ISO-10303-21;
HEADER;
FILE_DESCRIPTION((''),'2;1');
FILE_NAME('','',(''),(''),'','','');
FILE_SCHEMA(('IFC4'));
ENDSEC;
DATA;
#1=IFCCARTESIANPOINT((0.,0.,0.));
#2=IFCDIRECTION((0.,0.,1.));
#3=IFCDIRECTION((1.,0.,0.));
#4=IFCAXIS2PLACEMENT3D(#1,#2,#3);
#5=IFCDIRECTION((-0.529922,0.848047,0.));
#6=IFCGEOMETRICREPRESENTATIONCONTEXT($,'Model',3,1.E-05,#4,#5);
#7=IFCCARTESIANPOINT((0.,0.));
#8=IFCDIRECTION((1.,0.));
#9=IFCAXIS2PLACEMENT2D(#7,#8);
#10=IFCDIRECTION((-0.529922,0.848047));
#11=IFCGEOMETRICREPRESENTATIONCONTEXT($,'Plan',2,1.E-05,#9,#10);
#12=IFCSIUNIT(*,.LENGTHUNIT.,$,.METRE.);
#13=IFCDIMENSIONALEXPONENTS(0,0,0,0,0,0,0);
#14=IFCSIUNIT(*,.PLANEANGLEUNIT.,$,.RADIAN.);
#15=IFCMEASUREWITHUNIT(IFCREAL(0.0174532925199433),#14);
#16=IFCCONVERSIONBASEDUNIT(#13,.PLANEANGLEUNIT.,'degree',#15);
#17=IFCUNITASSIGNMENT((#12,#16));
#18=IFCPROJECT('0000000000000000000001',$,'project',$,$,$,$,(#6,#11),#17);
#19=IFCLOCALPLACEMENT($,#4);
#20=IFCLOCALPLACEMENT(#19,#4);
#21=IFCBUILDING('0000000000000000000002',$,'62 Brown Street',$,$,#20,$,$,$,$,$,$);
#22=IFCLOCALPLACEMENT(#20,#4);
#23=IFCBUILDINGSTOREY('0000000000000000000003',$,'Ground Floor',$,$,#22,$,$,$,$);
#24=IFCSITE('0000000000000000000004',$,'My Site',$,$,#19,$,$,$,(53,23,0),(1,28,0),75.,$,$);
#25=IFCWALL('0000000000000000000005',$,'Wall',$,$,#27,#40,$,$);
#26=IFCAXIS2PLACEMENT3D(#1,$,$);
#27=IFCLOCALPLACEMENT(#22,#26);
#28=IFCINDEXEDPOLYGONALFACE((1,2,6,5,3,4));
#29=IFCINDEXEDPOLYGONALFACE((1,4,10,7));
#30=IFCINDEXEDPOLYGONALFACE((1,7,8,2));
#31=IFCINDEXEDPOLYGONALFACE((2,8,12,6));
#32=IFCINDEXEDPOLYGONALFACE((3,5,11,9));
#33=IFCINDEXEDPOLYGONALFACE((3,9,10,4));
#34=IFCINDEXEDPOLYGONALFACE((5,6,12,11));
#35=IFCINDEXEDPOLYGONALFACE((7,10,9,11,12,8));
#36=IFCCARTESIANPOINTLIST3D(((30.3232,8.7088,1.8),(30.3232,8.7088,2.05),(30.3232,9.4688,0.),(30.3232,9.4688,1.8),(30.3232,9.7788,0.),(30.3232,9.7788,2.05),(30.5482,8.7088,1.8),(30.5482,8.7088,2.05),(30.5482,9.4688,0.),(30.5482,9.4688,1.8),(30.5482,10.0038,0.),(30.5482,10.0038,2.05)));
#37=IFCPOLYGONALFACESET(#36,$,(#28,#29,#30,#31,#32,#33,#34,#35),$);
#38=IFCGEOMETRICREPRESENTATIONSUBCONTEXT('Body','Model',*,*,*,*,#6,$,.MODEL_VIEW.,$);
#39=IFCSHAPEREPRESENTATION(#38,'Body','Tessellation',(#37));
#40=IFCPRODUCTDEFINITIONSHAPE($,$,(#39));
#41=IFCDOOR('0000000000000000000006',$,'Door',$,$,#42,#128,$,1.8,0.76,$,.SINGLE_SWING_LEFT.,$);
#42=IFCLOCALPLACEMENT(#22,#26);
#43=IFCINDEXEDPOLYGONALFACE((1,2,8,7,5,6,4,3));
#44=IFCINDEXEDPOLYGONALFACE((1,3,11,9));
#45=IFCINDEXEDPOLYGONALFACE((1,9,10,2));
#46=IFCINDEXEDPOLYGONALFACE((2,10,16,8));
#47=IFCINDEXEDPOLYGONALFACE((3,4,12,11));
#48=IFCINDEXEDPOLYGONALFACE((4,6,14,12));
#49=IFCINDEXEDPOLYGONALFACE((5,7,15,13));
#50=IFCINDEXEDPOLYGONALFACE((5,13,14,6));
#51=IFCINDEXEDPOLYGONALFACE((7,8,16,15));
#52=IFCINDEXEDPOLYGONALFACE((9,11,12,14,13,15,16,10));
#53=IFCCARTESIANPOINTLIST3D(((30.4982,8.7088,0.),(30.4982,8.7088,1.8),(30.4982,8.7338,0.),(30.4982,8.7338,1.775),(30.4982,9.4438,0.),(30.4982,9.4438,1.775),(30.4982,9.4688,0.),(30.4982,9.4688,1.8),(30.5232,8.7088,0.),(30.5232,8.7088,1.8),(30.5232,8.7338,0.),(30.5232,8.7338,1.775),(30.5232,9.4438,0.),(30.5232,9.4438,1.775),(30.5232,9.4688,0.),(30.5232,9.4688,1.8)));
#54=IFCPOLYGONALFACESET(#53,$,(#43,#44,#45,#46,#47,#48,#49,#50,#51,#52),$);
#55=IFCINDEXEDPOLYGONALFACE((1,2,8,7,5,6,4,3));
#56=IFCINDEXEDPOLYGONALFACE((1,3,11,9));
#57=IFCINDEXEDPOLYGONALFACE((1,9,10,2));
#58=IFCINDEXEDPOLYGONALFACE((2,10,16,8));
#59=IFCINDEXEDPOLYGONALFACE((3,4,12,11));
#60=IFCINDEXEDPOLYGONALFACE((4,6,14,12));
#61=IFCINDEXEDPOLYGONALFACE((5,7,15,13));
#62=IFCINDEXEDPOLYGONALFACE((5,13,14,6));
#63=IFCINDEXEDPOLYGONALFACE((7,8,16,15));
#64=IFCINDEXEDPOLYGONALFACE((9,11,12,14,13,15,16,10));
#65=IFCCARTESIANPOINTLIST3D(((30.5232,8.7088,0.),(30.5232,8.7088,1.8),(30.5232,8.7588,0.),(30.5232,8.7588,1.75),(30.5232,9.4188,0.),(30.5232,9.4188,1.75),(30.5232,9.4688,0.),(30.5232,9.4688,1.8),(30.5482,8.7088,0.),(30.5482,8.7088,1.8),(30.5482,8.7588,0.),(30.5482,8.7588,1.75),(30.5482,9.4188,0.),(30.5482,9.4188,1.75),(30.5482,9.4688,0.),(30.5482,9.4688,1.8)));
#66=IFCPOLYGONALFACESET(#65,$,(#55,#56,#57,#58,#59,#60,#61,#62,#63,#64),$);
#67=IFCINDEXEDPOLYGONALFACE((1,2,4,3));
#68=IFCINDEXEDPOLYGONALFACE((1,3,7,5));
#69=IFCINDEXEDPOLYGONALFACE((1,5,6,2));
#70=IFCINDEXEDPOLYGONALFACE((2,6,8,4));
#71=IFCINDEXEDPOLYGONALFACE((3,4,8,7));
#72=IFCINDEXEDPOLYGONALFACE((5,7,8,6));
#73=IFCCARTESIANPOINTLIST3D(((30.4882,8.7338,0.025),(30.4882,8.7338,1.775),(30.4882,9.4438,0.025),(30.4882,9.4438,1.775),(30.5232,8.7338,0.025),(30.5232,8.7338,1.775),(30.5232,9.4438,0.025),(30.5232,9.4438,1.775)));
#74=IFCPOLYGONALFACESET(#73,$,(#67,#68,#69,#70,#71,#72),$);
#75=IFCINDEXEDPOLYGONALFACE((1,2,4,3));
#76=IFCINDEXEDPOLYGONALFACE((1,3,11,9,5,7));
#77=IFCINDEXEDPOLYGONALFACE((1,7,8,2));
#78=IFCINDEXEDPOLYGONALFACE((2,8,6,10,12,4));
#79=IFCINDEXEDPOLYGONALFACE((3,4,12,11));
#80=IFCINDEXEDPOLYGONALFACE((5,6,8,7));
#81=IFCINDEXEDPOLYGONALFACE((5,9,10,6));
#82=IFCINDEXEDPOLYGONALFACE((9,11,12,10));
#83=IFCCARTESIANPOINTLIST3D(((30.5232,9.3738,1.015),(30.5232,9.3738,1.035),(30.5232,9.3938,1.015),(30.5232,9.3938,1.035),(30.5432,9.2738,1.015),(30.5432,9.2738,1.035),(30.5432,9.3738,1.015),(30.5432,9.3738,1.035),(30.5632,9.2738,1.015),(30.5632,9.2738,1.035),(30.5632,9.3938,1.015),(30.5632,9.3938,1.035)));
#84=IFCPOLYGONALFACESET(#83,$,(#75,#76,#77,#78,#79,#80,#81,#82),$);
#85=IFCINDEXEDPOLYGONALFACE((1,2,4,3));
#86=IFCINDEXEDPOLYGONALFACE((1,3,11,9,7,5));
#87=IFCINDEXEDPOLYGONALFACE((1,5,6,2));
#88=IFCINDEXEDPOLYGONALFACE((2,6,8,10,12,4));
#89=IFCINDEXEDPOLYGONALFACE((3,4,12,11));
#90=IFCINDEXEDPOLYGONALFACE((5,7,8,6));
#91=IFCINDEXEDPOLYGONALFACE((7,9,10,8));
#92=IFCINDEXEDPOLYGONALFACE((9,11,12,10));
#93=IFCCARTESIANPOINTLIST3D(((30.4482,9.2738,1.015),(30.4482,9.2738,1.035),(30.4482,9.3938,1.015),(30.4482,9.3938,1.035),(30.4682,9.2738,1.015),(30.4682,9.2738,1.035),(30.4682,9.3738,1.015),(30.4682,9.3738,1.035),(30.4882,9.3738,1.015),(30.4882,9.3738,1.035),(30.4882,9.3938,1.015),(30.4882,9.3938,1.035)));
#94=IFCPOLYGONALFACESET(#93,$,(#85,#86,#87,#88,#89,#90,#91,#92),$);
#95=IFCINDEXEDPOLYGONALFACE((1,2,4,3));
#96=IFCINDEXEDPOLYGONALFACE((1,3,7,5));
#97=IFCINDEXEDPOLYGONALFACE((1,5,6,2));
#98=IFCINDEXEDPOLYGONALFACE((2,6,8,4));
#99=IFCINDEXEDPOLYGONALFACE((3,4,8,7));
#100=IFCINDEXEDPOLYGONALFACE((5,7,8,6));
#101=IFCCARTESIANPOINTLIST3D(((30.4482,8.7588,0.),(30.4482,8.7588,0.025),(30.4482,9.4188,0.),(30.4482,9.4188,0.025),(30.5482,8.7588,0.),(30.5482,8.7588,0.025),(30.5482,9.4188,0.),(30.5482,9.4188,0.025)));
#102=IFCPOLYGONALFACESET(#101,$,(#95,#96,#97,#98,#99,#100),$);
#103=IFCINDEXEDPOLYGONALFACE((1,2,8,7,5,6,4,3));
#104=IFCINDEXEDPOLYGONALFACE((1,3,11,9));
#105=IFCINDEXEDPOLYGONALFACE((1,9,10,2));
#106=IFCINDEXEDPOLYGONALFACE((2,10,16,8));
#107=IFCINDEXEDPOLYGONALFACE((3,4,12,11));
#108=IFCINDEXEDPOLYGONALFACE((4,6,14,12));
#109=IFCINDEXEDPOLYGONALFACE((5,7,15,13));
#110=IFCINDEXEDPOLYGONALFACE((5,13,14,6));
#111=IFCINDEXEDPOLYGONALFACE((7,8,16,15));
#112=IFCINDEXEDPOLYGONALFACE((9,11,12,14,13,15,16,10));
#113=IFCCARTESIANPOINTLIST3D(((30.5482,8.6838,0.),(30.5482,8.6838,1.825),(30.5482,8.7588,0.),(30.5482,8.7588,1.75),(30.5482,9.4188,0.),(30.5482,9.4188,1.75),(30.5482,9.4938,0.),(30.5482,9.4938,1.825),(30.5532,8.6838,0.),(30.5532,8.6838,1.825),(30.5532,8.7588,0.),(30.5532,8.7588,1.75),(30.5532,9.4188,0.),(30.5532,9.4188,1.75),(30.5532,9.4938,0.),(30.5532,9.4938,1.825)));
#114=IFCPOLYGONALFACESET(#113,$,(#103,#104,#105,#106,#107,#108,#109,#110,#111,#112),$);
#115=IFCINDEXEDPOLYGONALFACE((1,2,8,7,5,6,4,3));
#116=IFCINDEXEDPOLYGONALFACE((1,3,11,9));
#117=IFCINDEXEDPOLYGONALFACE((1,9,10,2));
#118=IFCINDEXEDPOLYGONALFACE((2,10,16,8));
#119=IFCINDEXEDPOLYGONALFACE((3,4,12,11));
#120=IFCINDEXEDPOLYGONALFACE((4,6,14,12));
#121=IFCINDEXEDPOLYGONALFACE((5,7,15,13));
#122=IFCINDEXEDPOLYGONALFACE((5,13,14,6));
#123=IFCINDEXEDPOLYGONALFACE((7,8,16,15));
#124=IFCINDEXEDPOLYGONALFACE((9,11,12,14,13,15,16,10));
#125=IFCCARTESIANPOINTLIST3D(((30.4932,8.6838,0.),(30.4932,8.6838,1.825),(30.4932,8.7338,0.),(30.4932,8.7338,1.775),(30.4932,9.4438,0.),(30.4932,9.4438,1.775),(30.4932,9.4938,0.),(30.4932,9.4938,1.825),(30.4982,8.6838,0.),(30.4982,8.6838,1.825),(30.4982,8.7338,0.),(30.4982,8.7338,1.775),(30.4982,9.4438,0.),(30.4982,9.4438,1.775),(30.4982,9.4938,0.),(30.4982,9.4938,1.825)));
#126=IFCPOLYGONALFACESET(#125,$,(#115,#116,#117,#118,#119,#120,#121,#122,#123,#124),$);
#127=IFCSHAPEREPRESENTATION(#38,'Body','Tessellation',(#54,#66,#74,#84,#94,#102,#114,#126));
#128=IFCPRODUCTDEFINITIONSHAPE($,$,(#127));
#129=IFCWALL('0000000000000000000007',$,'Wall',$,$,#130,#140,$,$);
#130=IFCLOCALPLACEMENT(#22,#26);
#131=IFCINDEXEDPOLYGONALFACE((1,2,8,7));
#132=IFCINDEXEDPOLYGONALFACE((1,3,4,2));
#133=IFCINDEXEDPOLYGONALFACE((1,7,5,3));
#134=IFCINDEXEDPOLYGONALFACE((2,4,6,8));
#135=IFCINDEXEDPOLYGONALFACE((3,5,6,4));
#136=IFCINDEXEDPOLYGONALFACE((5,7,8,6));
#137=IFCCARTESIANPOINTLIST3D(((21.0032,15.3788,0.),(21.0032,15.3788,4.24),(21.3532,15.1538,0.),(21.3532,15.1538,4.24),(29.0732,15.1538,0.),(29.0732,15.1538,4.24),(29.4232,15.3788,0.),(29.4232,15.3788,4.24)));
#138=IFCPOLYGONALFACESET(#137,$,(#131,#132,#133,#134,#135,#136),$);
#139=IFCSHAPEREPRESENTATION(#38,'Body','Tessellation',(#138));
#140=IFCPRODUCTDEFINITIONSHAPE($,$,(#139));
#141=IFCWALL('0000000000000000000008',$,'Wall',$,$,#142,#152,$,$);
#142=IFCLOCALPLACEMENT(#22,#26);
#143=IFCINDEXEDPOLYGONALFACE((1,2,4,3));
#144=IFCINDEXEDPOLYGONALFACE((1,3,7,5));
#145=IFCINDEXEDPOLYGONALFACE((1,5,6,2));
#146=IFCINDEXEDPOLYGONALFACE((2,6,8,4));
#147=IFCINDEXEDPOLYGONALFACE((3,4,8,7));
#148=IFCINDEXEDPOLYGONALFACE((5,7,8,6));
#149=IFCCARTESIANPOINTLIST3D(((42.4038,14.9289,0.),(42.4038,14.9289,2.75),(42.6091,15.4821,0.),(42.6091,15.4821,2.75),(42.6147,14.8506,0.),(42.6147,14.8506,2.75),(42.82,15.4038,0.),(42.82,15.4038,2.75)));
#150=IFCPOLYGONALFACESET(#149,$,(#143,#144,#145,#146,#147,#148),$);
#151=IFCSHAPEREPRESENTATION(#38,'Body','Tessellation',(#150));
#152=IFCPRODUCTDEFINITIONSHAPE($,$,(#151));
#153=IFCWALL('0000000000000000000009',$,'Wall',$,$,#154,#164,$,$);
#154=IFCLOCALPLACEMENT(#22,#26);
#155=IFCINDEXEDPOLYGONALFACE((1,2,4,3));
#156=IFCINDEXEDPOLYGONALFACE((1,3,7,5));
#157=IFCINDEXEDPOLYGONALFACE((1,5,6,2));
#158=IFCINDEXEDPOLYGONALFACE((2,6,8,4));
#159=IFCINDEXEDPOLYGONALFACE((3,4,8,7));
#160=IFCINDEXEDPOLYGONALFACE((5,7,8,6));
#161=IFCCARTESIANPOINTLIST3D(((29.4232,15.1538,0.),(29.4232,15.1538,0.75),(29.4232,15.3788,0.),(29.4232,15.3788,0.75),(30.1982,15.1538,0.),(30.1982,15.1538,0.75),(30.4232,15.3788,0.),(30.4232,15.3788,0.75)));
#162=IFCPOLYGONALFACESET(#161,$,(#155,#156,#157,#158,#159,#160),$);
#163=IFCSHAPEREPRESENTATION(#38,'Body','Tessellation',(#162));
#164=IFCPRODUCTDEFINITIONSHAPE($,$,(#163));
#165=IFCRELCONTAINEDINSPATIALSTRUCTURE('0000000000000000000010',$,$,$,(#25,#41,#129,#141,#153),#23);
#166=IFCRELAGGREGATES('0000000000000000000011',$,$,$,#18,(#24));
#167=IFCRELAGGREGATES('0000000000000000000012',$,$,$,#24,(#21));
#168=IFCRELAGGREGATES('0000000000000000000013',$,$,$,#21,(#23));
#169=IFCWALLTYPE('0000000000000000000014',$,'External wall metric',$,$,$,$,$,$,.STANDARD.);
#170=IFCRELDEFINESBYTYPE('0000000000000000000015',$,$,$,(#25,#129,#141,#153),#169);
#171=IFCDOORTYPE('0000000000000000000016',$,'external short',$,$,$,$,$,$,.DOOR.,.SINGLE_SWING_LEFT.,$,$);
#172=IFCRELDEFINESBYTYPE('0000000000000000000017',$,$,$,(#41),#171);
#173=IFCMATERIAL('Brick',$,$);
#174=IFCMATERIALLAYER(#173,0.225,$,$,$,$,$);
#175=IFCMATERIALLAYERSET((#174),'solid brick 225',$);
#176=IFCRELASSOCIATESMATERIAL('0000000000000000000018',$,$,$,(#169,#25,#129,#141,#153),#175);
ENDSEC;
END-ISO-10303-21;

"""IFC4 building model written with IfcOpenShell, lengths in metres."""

from ifc_helpers import new_model, entity, si_unit, converted_unit, direction, frame, origin_with_axes, origin_2d_with_axis, place, context, subcontext, project, spatial, line, indexed_curve, outline, extrude, clip, halfspace, shape, source, transform, mapped, material, layer, layer_set, layer_usage, type_object, type_shapes, element, fill, save


model = new_model("IFC4")

# Units and contexts
model_context = context("Model", 3, precision=1e-05, world=origin_with_axes(), true_north=direction((-0.529922, 0.848047, 0.0)))
plan_context = context("Plan", 2, precision=1e-05, world=origin_2d_with_axis(), true_north=direction((-0.529922, 0.848047)))
body_context_1 = subcontext(model_context, "Body", "Model", "MODEL_VIEW")
body_context_2 = subcontext(plan_context, "Body", "Plan", "PLAN_VIEW")
ifc_project = project(units=[si_unit("LENGTHUNIT", "METRE"), converted_unit("PLANEANGLEUNIT", "degree", entity("IfcReal", 0.0174532925199433), si_unit("PLANEANGLEUNIT", "RADIAN"), dimensions=[0, 0, 0, 0, 0, 0, 0])], contexts=[model_context, plan_context])

# Site, building, storey
site_placement = place(None, origin_with_axes())
site = spatial("IfcSite", under=ifc_project, at=site_placement, Name="My Site", RefLatitude=(53, 23, 0), RefLongitude=(1, 28, 0), RefElevation=75.0)
building_placement = place(site_placement, origin_with_axes())
building = spatial("IfcBuilding", under=site, at=building_placement, Name="62 Brown Street")
storey_placement = place(building_placement, origin_with_axes())
storey = spatial("IfcBuildingStorey", under=building, at=storey_placement, Name="Ground Floor")

# Shared definitions
ifc_material_1 = material(Name="Brick")
ifc_layer_1 = layer(ifc_material_1, 0.225)
ifc_layer_set_1 = layer_set([ifc_layer_1], Name="solid brick 225")
wall_type_1 = type_object("IfcWallType", Name="External wall metric", PredefinedType="STANDARD", material=ifc_layer_set_1)

# Wall, opening, door
ifc_layer_usage_1 = layer_usage(ifc_layer_set_1, "AXIS2", "POSITIVE", 0.0)
wall_1_placement = place(storey_placement, frame((30.5482, 8.7088, 0.0), z_axis=(0.0, 0.0, 1.0), x_axis=(0.0, 1.0, 0.0)))
wall_1 = element("IfcWall", 1, at=wall_1_placement, inside=storey, type_object=wall_type_1, material=ifc_layer_usage_1, Name="Wall", context=body_context_1, shape_type="Clipping", body=[
    clip(extrude(outline(indexed_curve([(0.0, 0.0), (0.0, 0.225), (1.295, 0.225), (1.295, 0.0), (0.0, 0.0)], self_intersect=False)), origin_with_axes(), (0.0, 0.0, 1.0), 2.05), halfspace(frame((1.295, 0.0, 0.0), z_axis=(0.450001, 0.450001, 0.0), x_axis=(-0.225, 0.225, 0.0)), False)),
])
shared_shape_1 = source(origin_with_axes(), body_context_1, "Body", "SweptSolid", [
    extrude(outline(indexed_curve([(0.0, 0.0), (0.76, 0.0), (0.76, 1.8), (0.0, 1.8)], segments=[line(1, 2, 3, 4, 1)])), frame((0.0, -0.1, 0.0), z_axis=(0.0, -1.0, 0.0), x_axis=(1.0, 0.0, 0.0)), (0.0, 0.0, -1.0), 0.425),
])
opening_1_placement = place(wall_1_placement, frame((0.0, 0.0, 0.0), z_axis=(0.0, 0.0, 1.0), x_axis=(1.0, 0.0, 0.0)))
opening_1 = element("IfcOpeningElement", 2, at=opening_1_placement, cuts=wall_1, PredefinedType="OPENING", context=body_context_1, shape_type="MappedRepresentation", body=[
    mapped(shared_shape_1, transform((0.0, 0.0, 0.0), x_axis=(1.0, 0.0, 0.0), y_axis=(0.0, 1.0, 0.0), z_axis=(0.0, 0.0, 1.0), scale=1.0)),
])
door_type_1 = type_object("IfcDoorType", Name="external short", OperationType="SINGLE_SWING_LEFT", PredefinedType="DOOR")
shared_shape_2 = source(origin_with_axes(), body_context_1, "Body", "SweptSolid", [
    extrude(outline(indexed_curve([(0.0, 0.0), (0.0, 1.8), (0.76, 1.8), (0.76, 0.0), (0.735, 0.0), (0.735, 1.775), (0.025, 1.775), (0.025, 0.0)], segments=[line(1, 2, 3, 4, 5, 6, 7, 8, 1)])), frame((0.0, 0.025, 0.0), z_axis=(0.0, -1.0, 0.0), x_axis=(1.0, 0.0, 0.0)), (0.0, 0.0, -1.0), 0.025),
    extrude(outline(indexed_curve([(0.0, 0.0), (0.0, 1.8), (0.76, 1.8), (0.76, 0.0), (0.71, 0.0), (0.71, 1.75), (0.05, 1.75), (0.05, 0.0)], segments=[line(1, 2, 3, 4, 5, 6, 7, 8, 1)])), frame((0.0, 0.0, 0.0), z_axis=(0.0, -1.0, 0.0), x_axis=(1.0, 0.0, 0.0)), (0.0, 0.0, -1.0), 0.025),
    extrude(outline(indexed_curve([(0.0, 0.0), (0.71, 0.0), (0.71, 0.035), (0.0, 0.035)], segments=[line(1, 2, 3, 4, 1)])), frame((0.025, 0.025, 0.025), z_axis=(0.0, 0.0, 1.0), x_axis=(1.0, 0.0, 0.0)), (0.0, 0.0, 1.0), 1.75),
    extrude(outline(indexed_curve([(0.0, 0.0), (0.0, -0.04), (-0.12, -0.04), (-0.12, -0.02), (-0.02, -0.02), (-0.02, 0.0)], segments=[line(1, 2, 3, 4, 5, 6, 1)])), frame((0.685, 0.025, 1.015), z_axis=(0.0, 0.0, 1.0), x_axis=(1.0, 0.0, 0.0)), (0.0, 0.0, 1.0), 0.02),
    extrude(outline(indexed_curve([(0.0, 0.0), (0.0, 0.04), (-0.12, 0.04), (-0.12, 0.02), (-0.02, 0.02), (-0.02, 0.0)], segments=[line(1, 2, 3, 4, 5, 6, 1)])), frame((0.685, 0.06, 1.015), z_axis=(0.0, 0.0, 1.0), x_axis=(1.0, 0.0, 0.0)), (0.0, 0.0, 1.0), 0.02),
    extrude(outline(indexed_curve([(0.0, 0.0), (0.66, 0.0), (0.66, 0.1), (0.0, 0.1)], segments=[line(1, 2, 3, 4, 1)])), frame((0.05, 0.0, 0.0), z_axis=(0.0, 0.0, 1.0), x_axis=(1.0, 0.0, 0.0)), (0.0, 0.0, 1.0), 0.025),
    extrude(outline(indexed_curve([(0.0, 0.0), (0.0, 1.825), (0.81, 1.825), (0.81, 0.0), (0.735, 0.0), (0.735, 1.75), (0.075, 1.75), (0.075, 0.0)], segments=[line(1, 2, 3, 4, 5, 6, 7, 8, 1)])), frame((-0.025, -0.005, 0.0), z_axis=(0.0, -1.0, 0.0), x_axis=(1.0, 0.0, 0.0)), (0.0, 0.0, -1.0), 0.005),
    extrude(outline(indexed_curve([(0.0, 0.0), (0.0, 1.825), (0.81, 1.825), (0.81, 0.0), (0.76, 0.0), (0.76, 1.775), (0.05, 1.775), (0.05, 0.0)], segments=[line(1, 2, 3, 4, 5, 6, 7, 8, 1)])), frame((-0.025, 0.05, 0.0), z_axis=(0.0, -1.0, 0.0), x_axis=(1.0, 0.0, 0.0)), (0.0, 0.0, -1.0), 0.005),
])
shared_shape_3 = source(origin_with_axes(), body_context_2, "Body", "Curve2D", [
    entity("IfcIndexedPolyCurve", entity("IfcCartesianPointList2D", [[0.0, 0.0], [0.0, 0.05], [0.025, 0.05], [0.025, 0.025], [0.05, 0.025], [0.05, 0.0]]), [entity("IfcLineIndex", [1, 2, 3, 4, 5, 6, 1])]),
    entity("IfcIndexedPolyCurve", entity("IfcCartesianPointList2D", [[0.76, 0.0], [0.76, 0.05], [0.735, 0.05], [0.735, 0.025], [0.71, 0.025], [0.71, 0.0]]), [entity("IfcLineIndex", [1, 2, 3, 4, 5, 6, 1])]),
    entity("IfcTrimmedCurve", entity("IfcEllipse", entity("IfcAxis2Placement2D", entity("IfcCartesianPoint", [0.06, 0.05]), entity("IfcDirection", [1.0, 0.0])), 0.675, 0.71), [entity("IfcCartesianPoint", [0.735, 0.05])], [entity("IfcCartesianPoint", [0.06, 0.76])], True, "CARTESIAN"),
    entity("IfcIndexedPolyCurve", entity("IfcCartesianPointList2D", [[0.025, 0.05], [0.06, 0.05], [0.06, 0.76], [0.025, 0.76]]), [entity("IfcLineIndex", [1, 2, 3, 4, 1])]),
])
type_shapes(door_type_1, [shared_shape_2, shared_shape_3])
door_1_placement = place(opening_1_placement, frame((0.0, 0.0, 0.0), z_axis=(0.0, 0.0, 1.0), x_axis=(1.0, 0.0, 0.0)))
door_1 = element("IfcDoor", 3, at=door_1_placement, inside=storey, type_object=door_type_1, Name="Door", OperationType="SINGLE_SWING_LEFT", OverallHeight=1.8, OverallWidth=0.76, shapes=[
    shape(body_context_1, "Body", "MappedRepresentation", [mapped(shared_shape_2, transform((0.0, 0.0, 0.0), x_axis=(1.0, 0.0, 0.0), y_axis=(0.0, 1.0, 0.0), z_axis=(0.0, 0.0, 1.0), scale=1.0))]),
    shape(body_context_2, "Body", "MappedRepresentation", [mapped(shared_shape_3, transform((0.0, 0.0, 0.0), x_axis=(1.0, 0.0, 0.0), y_axis=(0.0, 1.0, 0.0), z_axis=(0.0, 0.0, 1.0), scale=1.0))]),
])
fill(opening_1, door_1)

# Walls
ifc_layer_usage_2 = layer_usage(ifc_layer_set_1, "AXIS2", "POSITIVE", 0.0)
wall_2_placement = place(storey_placement, frame((29.4232, 15.3788, 0.0), z_axis=(0.0, 0.0, 1.0), x_axis=(-1.0, 0.0, 0.0)))
element("IfcWall", 4, at=wall_2_placement, inside=storey, type_object=wall_type_1, material=ifc_layer_usage_2, Name="Wall", context=body_context_1, shape_type="Clipping", body=[
    clip(clip(extrude(outline(indexed_curve([(0.0, 0.0), (0.0, 0.225), (8.42, 0.225), (8.42, 0.0), (0.0, 0.0)], self_intersect=False)), origin_with_axes(), (0.0, 0.0, 1.0), 4.24), halfspace(frame((8.42, 0.0, 0.0), z_axis=(0.540756, 0.841179, 0.0), x_axis=(-0.841179, 0.540756, 0.0)), False)), halfspace(frame((0.0, 0.0, 0.0), z_axis=(-0.540758, 0.841178, 0.0), x_axis=(0.841178, 0.540758, 0.0)), False)),
])
ifc_layer_usage_3 = layer_usage(ifc_layer_set_1, "AXIS2", "POSITIVE", 0.0)
wall_3_placement = place(storey_placement, frame((42.6147, 14.8506, 0.0), z_axis=(0.0, 0.0, 1.0), x_axis=(0.347944, 0.937515, 0.0)))
element("IfcWall", 5, at=wall_3_placement, inside=storey, type_object=wall_type_1, material=ifc_layer_usage_3, Name="Wall", context=body_context_1, shape_type="SweptSolid", body=[
    extrude(outline(indexed_curve([(0.0, 0.0), (0.0, 0.225), (0.5901, 0.225), (0.5901, 0.0), (0.0, 0.0)], self_intersect=False)), origin_with_axes(), (0.0, 0.0, 1.0), 2.75),
])
ifc_layer_usage_4 = layer_usage(ifc_layer_set_1, "AXIS2", "POSITIVE", 0.0)
wall_4_placement = place(storey_placement, frame((30.4232, 15.3788, 0.0), z_axis=(0.0, 0.0, 1.0), x_axis=(-1.0, 0.0, 0.0)))
element("IfcWall", 6, at=wall_4_placement, inside=storey, type_object=wall_type_1, material=ifc_layer_usage_4, Name="Wall", context=body_context_1, shape_type="Clipping", body=[
    clip(extrude(outline(indexed_curve([(0.0, 0.0), (0.0, 0.225), (1.0, 0.225), (1.0, 0.0), (0.0, 0.0)], self_intersect=False)), origin_with_axes(), (0.0, 0.0, 1.0), 0.75), halfspace(frame((0.0, 0.0, 0.0), z_axis=(-0.707107, 0.707107, 0.0), x_axis=(0.707107, 0.707107, 0.0)), False)),
])

save(model, "model.ifc")
